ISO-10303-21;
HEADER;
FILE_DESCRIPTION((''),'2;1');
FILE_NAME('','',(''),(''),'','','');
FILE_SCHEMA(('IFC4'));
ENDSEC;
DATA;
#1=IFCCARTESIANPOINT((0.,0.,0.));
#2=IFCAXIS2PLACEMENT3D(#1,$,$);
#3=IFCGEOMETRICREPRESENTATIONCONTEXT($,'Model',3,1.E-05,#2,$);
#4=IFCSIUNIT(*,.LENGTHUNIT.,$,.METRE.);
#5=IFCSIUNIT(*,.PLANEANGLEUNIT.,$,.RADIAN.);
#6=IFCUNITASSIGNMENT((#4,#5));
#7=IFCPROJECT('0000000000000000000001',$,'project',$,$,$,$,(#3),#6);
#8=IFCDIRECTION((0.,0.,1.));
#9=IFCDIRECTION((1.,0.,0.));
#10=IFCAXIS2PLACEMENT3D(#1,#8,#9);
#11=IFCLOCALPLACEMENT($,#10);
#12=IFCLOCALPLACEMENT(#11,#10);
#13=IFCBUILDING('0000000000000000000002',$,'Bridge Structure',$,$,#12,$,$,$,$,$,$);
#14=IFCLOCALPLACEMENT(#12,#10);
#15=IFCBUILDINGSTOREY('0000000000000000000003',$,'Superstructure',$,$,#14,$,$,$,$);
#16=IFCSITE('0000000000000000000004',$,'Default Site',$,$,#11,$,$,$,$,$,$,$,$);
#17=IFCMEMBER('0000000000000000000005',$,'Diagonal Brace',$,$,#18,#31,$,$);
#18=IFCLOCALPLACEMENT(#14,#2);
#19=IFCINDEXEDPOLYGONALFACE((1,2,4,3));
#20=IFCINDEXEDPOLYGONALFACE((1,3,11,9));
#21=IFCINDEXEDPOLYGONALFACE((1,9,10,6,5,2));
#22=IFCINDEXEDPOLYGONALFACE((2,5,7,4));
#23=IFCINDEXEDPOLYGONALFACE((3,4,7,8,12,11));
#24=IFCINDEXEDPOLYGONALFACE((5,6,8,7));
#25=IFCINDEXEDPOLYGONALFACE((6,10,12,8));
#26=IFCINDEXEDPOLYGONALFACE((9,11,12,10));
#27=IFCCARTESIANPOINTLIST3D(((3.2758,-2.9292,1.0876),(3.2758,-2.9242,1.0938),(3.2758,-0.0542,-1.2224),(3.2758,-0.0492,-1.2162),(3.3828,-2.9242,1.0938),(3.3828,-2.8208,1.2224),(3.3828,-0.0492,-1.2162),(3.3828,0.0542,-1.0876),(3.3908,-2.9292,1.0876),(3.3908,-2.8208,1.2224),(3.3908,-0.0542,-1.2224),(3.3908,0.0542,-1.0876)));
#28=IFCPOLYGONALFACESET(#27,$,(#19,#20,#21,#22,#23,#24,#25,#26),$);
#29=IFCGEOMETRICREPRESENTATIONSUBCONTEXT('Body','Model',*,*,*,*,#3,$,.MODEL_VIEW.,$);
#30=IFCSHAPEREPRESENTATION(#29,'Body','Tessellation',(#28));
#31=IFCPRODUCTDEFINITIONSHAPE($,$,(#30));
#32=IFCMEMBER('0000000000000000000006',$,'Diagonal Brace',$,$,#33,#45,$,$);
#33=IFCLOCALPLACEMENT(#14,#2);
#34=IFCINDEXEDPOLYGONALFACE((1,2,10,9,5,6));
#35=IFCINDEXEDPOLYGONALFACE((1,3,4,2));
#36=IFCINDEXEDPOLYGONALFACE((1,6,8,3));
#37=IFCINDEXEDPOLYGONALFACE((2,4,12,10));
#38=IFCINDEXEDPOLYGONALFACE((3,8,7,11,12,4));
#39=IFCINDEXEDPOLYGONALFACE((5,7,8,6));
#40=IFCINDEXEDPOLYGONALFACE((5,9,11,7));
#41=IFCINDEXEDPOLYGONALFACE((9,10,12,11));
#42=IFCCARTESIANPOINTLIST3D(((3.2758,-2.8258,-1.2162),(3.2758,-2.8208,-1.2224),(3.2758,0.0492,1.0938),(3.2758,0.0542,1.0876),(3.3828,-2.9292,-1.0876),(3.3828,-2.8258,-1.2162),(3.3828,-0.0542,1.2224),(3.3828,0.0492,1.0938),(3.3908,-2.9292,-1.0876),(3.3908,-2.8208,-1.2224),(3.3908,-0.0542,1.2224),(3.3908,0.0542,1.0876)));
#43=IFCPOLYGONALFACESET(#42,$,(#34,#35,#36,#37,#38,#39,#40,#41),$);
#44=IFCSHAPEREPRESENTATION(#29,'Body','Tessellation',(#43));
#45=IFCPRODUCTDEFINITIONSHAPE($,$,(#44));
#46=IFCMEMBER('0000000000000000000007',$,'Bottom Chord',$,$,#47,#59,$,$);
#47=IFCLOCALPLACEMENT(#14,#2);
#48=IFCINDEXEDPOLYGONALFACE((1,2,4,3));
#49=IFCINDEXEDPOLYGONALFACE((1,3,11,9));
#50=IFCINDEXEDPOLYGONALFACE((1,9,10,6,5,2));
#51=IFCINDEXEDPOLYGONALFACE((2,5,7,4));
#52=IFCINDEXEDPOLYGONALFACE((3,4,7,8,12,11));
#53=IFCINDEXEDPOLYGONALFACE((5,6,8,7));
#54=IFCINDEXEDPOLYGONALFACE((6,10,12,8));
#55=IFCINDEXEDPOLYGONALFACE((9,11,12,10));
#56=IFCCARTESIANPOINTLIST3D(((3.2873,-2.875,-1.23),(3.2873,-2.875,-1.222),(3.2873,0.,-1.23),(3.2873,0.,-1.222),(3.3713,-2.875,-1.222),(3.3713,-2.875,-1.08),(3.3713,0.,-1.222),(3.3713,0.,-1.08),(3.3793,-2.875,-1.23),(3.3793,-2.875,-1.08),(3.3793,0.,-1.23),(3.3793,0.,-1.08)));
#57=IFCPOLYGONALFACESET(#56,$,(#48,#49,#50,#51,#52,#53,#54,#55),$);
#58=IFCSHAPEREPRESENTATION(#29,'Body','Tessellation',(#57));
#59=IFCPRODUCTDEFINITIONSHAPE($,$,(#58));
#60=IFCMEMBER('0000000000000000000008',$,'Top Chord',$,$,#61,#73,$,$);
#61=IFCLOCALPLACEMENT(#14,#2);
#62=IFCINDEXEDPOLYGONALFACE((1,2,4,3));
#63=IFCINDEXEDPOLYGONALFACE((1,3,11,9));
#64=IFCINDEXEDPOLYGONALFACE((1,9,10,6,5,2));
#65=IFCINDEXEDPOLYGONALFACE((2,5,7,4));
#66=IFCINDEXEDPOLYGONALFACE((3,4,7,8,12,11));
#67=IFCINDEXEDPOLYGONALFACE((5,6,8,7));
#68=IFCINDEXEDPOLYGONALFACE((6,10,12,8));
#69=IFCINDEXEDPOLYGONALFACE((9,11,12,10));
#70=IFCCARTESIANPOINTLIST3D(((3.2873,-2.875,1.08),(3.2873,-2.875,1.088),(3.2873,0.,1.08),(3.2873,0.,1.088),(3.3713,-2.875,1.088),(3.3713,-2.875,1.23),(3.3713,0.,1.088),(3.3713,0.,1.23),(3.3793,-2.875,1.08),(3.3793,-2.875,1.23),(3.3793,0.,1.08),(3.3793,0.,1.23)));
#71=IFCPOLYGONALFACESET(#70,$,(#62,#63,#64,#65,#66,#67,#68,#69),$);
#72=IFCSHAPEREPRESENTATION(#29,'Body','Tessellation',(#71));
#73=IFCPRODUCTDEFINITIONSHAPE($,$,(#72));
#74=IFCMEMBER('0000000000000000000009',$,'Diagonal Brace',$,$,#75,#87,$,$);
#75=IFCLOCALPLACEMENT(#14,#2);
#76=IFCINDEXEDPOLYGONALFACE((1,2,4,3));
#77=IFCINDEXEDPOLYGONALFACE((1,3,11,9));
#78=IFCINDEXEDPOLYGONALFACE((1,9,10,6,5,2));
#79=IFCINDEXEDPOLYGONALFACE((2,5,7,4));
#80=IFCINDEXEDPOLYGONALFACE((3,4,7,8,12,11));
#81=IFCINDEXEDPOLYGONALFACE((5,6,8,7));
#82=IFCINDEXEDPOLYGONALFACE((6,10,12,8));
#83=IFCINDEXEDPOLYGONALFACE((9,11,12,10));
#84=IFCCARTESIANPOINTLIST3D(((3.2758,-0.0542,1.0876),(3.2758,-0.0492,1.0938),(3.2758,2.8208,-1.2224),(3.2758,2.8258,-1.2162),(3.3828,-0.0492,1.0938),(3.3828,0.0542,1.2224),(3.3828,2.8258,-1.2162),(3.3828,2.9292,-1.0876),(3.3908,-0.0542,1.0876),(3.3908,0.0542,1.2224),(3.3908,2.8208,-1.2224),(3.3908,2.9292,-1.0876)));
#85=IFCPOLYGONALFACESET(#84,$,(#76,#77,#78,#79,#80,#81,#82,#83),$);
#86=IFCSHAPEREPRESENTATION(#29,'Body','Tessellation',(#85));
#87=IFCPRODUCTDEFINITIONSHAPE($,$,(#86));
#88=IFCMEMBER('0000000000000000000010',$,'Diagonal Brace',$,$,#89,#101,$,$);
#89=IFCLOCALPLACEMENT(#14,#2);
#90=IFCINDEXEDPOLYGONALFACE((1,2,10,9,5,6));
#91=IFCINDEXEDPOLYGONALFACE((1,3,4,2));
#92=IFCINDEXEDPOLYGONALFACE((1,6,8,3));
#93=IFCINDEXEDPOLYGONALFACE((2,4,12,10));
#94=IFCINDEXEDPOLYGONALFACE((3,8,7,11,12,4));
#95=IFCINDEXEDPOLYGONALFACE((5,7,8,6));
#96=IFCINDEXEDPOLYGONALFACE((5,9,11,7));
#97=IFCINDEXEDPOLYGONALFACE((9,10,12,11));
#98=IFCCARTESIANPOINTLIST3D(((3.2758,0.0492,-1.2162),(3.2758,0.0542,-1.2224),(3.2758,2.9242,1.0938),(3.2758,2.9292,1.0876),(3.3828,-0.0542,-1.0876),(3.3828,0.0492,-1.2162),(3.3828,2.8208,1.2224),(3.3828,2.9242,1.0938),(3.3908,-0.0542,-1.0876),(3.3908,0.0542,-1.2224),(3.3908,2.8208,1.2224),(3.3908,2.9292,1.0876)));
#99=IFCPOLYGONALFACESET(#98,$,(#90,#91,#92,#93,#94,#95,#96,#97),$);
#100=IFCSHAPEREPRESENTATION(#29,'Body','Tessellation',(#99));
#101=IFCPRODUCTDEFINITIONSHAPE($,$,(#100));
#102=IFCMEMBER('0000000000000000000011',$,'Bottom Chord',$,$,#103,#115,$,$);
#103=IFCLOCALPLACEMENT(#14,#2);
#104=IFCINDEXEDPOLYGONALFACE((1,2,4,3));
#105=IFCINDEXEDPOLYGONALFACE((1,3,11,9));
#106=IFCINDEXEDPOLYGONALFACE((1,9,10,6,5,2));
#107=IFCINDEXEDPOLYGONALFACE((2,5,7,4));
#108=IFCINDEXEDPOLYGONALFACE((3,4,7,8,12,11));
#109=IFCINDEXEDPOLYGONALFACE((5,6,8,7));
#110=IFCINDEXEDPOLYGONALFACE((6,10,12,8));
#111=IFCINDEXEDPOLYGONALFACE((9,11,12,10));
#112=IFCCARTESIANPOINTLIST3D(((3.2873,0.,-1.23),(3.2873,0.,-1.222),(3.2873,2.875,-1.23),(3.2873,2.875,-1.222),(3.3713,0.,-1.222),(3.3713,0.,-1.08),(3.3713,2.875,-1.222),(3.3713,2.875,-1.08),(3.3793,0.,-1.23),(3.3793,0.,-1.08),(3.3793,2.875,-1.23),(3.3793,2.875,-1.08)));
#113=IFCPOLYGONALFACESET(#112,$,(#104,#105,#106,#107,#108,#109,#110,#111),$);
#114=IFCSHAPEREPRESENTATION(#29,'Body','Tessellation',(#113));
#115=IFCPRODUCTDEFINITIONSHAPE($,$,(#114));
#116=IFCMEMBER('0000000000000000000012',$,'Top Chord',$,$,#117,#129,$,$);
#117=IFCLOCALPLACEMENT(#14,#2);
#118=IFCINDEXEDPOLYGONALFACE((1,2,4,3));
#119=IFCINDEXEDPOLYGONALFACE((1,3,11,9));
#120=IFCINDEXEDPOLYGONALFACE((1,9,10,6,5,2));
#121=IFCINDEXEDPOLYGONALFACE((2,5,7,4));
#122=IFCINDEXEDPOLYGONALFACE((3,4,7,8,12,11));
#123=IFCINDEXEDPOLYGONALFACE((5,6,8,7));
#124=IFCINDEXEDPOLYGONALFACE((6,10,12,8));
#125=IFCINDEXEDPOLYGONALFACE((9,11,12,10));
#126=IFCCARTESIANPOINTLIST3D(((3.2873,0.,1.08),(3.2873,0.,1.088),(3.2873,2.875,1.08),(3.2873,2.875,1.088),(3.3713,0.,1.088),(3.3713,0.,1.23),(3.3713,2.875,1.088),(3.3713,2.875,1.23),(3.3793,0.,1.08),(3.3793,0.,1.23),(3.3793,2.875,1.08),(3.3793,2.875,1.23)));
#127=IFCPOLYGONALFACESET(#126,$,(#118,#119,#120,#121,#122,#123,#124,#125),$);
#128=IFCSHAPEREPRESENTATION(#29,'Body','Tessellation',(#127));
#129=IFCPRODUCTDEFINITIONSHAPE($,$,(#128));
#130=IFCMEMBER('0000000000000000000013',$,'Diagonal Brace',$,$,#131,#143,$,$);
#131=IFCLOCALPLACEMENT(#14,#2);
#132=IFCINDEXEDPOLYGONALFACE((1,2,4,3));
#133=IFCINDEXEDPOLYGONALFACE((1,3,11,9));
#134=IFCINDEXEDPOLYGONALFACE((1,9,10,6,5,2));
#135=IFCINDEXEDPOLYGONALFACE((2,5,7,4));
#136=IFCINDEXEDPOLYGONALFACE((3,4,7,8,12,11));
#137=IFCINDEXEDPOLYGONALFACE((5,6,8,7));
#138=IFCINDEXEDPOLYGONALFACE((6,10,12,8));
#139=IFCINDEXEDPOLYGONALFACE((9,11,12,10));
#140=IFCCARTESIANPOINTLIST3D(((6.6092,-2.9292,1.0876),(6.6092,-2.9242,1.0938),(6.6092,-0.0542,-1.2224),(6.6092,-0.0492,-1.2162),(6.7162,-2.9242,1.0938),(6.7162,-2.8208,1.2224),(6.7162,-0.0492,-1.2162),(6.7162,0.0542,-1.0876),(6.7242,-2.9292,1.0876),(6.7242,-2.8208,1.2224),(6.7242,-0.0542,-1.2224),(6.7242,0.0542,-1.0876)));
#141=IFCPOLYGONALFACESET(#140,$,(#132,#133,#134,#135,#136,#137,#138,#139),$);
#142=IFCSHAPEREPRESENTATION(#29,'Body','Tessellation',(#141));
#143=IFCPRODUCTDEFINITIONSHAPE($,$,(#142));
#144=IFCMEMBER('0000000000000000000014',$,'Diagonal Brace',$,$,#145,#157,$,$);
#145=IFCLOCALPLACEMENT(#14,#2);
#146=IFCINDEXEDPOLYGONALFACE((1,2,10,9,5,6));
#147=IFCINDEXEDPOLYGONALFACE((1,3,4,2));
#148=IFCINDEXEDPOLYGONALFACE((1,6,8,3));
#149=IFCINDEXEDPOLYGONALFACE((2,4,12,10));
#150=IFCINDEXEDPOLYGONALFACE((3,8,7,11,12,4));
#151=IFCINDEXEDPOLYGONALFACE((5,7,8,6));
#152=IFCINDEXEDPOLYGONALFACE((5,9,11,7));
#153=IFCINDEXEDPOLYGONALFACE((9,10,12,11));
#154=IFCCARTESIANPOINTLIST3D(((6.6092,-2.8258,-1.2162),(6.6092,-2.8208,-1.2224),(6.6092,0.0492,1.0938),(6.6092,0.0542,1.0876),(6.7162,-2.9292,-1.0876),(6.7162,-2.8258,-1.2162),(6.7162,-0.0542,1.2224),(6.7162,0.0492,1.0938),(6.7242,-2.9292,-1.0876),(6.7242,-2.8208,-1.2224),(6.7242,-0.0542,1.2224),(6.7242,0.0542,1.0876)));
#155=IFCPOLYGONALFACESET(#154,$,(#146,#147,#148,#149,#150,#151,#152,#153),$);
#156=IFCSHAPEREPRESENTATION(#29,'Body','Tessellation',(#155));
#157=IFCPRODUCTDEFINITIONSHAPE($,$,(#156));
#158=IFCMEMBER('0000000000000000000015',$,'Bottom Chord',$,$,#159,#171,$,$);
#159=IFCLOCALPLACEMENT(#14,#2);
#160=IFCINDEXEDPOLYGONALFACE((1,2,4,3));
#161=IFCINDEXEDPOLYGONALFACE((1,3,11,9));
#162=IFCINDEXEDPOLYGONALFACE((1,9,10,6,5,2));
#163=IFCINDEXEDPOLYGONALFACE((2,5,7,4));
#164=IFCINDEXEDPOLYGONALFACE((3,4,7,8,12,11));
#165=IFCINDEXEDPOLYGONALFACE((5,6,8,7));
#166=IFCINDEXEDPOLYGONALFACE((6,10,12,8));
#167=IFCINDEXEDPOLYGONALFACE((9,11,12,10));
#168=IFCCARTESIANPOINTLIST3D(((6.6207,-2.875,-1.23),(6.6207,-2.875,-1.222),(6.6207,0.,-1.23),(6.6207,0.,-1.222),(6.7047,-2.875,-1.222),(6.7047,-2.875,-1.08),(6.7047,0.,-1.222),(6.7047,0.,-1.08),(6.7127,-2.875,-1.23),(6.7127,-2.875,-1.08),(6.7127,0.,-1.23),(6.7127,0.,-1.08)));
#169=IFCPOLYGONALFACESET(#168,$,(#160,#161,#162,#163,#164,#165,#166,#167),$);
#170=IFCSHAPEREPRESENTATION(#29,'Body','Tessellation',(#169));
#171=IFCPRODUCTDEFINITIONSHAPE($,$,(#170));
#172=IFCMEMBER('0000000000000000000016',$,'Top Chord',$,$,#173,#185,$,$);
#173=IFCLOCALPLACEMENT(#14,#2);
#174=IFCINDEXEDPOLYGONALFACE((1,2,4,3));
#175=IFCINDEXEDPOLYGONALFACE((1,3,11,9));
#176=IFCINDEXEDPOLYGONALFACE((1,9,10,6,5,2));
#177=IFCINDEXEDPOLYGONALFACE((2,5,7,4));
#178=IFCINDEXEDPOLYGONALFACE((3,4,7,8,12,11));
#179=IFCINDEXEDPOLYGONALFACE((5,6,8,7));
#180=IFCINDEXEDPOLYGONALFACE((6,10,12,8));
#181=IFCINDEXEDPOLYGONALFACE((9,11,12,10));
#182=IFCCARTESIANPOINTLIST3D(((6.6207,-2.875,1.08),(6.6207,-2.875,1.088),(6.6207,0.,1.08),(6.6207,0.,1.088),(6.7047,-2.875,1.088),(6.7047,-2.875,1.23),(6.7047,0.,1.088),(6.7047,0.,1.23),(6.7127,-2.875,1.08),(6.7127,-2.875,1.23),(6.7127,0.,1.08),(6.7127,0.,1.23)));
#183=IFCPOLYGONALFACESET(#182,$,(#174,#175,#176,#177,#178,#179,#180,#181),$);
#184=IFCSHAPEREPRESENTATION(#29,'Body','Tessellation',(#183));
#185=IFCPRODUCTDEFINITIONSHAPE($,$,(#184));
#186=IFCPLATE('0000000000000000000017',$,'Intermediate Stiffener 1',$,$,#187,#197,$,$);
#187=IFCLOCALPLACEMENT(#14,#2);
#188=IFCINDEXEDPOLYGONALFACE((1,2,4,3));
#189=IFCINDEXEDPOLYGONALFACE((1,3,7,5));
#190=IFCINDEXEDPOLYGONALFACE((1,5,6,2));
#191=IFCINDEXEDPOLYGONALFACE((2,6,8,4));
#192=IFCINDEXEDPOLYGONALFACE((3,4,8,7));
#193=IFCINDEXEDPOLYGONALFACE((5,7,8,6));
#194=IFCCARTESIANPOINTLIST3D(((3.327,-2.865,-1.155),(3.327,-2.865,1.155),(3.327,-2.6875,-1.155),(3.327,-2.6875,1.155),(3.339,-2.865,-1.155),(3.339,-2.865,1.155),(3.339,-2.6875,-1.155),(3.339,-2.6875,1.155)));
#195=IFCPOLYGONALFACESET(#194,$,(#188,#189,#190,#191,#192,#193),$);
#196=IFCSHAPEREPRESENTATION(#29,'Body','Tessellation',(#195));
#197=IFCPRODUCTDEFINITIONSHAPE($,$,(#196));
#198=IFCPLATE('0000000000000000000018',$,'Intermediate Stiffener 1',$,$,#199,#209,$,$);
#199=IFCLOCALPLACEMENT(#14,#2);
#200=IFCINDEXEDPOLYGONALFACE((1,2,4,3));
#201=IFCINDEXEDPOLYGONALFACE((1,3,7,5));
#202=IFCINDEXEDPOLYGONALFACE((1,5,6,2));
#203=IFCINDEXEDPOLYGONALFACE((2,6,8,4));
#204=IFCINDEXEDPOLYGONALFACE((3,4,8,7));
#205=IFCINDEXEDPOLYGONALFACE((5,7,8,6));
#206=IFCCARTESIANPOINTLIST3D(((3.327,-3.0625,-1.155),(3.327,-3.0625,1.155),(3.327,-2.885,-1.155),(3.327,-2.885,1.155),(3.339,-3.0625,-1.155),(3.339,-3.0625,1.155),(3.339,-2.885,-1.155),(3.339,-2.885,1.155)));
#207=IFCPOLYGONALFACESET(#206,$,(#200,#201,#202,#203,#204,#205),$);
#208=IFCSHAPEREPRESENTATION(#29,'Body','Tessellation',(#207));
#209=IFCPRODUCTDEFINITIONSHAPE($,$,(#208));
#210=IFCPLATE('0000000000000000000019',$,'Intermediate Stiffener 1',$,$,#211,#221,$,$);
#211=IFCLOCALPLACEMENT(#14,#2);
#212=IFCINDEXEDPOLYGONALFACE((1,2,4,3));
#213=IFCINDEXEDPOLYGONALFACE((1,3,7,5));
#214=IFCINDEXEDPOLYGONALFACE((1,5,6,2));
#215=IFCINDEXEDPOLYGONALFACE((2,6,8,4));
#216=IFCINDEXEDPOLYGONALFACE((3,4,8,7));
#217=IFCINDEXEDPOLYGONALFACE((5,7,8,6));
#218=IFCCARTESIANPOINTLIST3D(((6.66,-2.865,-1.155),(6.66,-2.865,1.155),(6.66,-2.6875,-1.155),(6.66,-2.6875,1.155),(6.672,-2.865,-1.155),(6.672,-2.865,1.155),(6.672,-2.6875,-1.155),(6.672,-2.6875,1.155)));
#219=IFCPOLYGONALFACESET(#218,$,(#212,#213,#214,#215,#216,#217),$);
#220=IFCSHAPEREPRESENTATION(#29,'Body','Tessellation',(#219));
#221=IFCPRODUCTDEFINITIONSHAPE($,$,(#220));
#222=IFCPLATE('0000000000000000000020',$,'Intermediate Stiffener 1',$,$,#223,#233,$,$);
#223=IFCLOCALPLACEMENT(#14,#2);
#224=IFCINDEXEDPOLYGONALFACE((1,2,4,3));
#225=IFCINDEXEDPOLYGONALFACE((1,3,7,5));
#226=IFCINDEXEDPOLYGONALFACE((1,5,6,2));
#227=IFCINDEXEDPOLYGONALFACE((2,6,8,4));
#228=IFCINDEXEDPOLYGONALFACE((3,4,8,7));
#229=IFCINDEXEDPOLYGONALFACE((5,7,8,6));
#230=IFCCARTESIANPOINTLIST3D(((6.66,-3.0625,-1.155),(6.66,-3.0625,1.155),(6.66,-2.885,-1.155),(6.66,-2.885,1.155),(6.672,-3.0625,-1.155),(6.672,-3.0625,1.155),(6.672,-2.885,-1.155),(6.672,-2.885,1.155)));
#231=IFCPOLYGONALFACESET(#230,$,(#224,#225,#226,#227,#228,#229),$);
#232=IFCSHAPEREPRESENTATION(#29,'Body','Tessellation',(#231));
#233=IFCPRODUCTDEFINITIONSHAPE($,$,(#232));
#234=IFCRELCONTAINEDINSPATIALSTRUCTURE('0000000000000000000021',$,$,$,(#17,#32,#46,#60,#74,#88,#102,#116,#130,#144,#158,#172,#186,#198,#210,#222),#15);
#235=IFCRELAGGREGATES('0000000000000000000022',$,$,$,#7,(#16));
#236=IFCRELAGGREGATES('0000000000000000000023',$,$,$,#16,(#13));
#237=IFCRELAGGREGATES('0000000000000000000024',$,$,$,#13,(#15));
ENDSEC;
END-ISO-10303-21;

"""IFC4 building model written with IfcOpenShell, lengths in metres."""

from ifc_helpers import new_model, si_unit, frame, origin, origin_with_axes, origin_2d_with_axis, place, context, subcontext, project, spatial, rectangle, l_section, extrude, element, save


model = new_model("IFC4")

# Units and contexts
model_context = context("Model", 3, precision=1e-05, world=origin())
body_context = subcontext(model_context, "Body", "Model", "MODEL_VIEW")
ifc_project = project(units=[si_unit("LENGTHUNIT", "METRE"), si_unit("PLANEANGLEUNIT", "RADIAN")], contexts=[model_context])

# Site, building, storey
site_placement = place(None, origin_with_axes())
site = spatial("IfcSite", under=ifc_project, at=site_placement, Name="Default Site")
building_placement = place(site_placement, origin_with_axes())
building = spatial("IfcBuilding", under=site, at=building_placement, Name="Bridge Structure")
storey_placement = place(building_placement, origin_with_axes())
storey = spatial("IfcBuildingStorey", under=building, at=storey_placement, Name="Superstructure")

# Members
for number, where, z_axis, x_axis, name in (
    (1, (3.3333, -2.875, 1.155), (0.0, 0.779544, -0.626347), (-1.0, 0.0, 0.0), "Diagonal Brace"),
    (2, (3.3333, -2.875, -1.155), (0.0, 0.779544, 0.626347), (-1.0, 0.0, 0.0), "Diagonal Brace"),
):
    element("IfcMember", number, at=place(storey_placement, frame(where, z_axis=z_axis, x_axis=x_axis)), inside=storey, Name=name, context=body_context, shape_type="SweptSolid", body=[
        extrude(l_section(Depth=0.173, Width=0.115, Thickness=0.008, at=origin_2d_with_axis()), origin_with_axes(), (0.0, 0.0, 1.0), 3.6881),
    ])
for number, where, z_axis, x_axis, name in (
    (3, (3.3333, -2.875, -1.155), (0.0, 1.0, 0.0), (-1.0, 0.0, 0.0), "Bottom Chord"),
    (4, (3.3333, -2.875, 1.155), (0.0, 1.0, 0.0), (-1.0, 0.0, 0.0), "Top Chord"),
):
    element("IfcMember", number, at=place(storey_placement, frame(where, z_axis=z_axis, x_axis=x_axis)), inside=storey, Name=name, context=body_context, shape_type="SweptSolid", body=[
        extrude(l_section(Depth=0.15, Width=0.092, Thickness=0.008, at=origin_2d_with_axis()), origin_with_axes(), (0.0, 0.0, 1.0), 2.875),
    ])
for number, where, z_axis, x_axis, name in (
    (5, (3.3333, 0.0, 1.155), (0.0, 0.779544, -0.626347), (-1.0, 0.0, 0.0), "Diagonal Brace"),
    (6, (3.3333, 0.0, -1.155), (0.0, 0.779544, 0.626347), (-1.0, 0.0, 0.0), "Diagonal Brace"),
):
    element("IfcMember", number, at=place(storey_placement, frame(where, z_axis=z_axis, x_axis=x_axis)), inside=storey, Name=name, context=body_context, shape_type="SweptSolid", body=[
        extrude(l_section(Depth=0.173, Width=0.115, Thickness=0.008, at=origin_2d_with_axis()), origin_with_axes(), (0.0, 0.0, 1.0), 3.6881),
    ])
for number, where, z_axis, x_axis, name in (
    (7, (3.3333, 0.0, -1.155), (0.0, 1.0, 0.0), (-1.0, 0.0, 0.0), "Bottom Chord"),
    (8, (3.3333, 0.0, 1.155), (0.0, 1.0, 0.0), (-1.0, 0.0, 0.0), "Top Chord"),
):
    element("IfcMember", number, at=place(storey_placement, frame(where, z_axis=z_axis, x_axis=x_axis)), inside=storey, Name=name, context=body_context, shape_type="SweptSolid", body=[
        extrude(l_section(Depth=0.15, Width=0.092, Thickness=0.008, at=origin_2d_with_axis()), origin_with_axes(), (0.0, 0.0, 1.0), 2.875),
    ])
for number, where, z_axis, x_axis, name in (
    (9, (6.6667, -2.875, 1.155), (0.0, 0.779544, -0.626347), (-1.0, 0.0, 0.0), "Diagonal Brace"),
    (10, (6.6667, -2.875, -1.155), (0.0, 0.779544, 0.626347), (-1.0, 0.0, 0.0), "Diagonal Brace"),
):
    element("IfcMember", number, at=place(storey_placement, frame(where, z_axis=z_axis, x_axis=x_axis)), inside=storey, Name=name, context=body_context, shape_type="SweptSolid", body=[
        extrude(l_section(Depth=0.173, Width=0.115, Thickness=0.008, at=origin_2d_with_axis()), origin_with_axes(), (0.0, 0.0, 1.0), 3.6881),
    ])
for number, where, z_axis, x_axis, name in (
    (11, (6.6667, -2.875, -1.155), (0.0, 1.0, 0.0), (-1.0, 0.0, 0.0), "Bottom Chord"),
    (12, (6.6667, -2.875, 1.155), (0.0, 1.0, 0.0), (-1.0, 0.0, 0.0), "Top Chord"),
):
    element("IfcMember", number, at=place(storey_placement, frame(where, z_axis=z_axis, x_axis=x_axis)), inside=storey, Name=name, context=body_context, shape_type="SweptSolid", body=[
        extrude(l_section(Depth=0.15, Width=0.092, Thickness=0.008, at=origin_2d_with_axis()), origin_with_axes(), (0.0, 0.0, 1.0), 2.875),
    ])

# Plates
for number, where, z_axis, x_axis, name in (
    (13, (3.333, -2.7763, -1.155), (0.0, 0.0, 1.0), (1.0, 0.0, 0.0), "Intermediate Stiffener 1"),
    (14, (3.333, -2.9737, -1.155), (0.0, 0.0, 1.0), (1.0, 0.0, 0.0), "Intermediate Stiffener 1"),
    (15, (6.666, -2.7763, -1.155), (0.0, 0.0, 1.0), (1.0, 0.0, 0.0), "Intermediate Stiffener 1"),
    (16, (6.666, -2.9737, -1.155), (0.0, 0.0, 1.0), (1.0, 0.0, 0.0), "Intermediate Stiffener 1"),
):
    element("IfcPlate", number, at=place(storey_placement, frame(where, z_axis=z_axis, x_axis=x_axis)), inside=storey, Name=name, context=body_context, shape_type="SweptSolid", body=[
        extrude(rectangle(XDim=0.012, YDim=0.1775, at=origin_2d_with_axis()), origin_with_axes(), (0.0, 0.0, 1.0), 2.31),
    ])

save(model, "model.ifc")
